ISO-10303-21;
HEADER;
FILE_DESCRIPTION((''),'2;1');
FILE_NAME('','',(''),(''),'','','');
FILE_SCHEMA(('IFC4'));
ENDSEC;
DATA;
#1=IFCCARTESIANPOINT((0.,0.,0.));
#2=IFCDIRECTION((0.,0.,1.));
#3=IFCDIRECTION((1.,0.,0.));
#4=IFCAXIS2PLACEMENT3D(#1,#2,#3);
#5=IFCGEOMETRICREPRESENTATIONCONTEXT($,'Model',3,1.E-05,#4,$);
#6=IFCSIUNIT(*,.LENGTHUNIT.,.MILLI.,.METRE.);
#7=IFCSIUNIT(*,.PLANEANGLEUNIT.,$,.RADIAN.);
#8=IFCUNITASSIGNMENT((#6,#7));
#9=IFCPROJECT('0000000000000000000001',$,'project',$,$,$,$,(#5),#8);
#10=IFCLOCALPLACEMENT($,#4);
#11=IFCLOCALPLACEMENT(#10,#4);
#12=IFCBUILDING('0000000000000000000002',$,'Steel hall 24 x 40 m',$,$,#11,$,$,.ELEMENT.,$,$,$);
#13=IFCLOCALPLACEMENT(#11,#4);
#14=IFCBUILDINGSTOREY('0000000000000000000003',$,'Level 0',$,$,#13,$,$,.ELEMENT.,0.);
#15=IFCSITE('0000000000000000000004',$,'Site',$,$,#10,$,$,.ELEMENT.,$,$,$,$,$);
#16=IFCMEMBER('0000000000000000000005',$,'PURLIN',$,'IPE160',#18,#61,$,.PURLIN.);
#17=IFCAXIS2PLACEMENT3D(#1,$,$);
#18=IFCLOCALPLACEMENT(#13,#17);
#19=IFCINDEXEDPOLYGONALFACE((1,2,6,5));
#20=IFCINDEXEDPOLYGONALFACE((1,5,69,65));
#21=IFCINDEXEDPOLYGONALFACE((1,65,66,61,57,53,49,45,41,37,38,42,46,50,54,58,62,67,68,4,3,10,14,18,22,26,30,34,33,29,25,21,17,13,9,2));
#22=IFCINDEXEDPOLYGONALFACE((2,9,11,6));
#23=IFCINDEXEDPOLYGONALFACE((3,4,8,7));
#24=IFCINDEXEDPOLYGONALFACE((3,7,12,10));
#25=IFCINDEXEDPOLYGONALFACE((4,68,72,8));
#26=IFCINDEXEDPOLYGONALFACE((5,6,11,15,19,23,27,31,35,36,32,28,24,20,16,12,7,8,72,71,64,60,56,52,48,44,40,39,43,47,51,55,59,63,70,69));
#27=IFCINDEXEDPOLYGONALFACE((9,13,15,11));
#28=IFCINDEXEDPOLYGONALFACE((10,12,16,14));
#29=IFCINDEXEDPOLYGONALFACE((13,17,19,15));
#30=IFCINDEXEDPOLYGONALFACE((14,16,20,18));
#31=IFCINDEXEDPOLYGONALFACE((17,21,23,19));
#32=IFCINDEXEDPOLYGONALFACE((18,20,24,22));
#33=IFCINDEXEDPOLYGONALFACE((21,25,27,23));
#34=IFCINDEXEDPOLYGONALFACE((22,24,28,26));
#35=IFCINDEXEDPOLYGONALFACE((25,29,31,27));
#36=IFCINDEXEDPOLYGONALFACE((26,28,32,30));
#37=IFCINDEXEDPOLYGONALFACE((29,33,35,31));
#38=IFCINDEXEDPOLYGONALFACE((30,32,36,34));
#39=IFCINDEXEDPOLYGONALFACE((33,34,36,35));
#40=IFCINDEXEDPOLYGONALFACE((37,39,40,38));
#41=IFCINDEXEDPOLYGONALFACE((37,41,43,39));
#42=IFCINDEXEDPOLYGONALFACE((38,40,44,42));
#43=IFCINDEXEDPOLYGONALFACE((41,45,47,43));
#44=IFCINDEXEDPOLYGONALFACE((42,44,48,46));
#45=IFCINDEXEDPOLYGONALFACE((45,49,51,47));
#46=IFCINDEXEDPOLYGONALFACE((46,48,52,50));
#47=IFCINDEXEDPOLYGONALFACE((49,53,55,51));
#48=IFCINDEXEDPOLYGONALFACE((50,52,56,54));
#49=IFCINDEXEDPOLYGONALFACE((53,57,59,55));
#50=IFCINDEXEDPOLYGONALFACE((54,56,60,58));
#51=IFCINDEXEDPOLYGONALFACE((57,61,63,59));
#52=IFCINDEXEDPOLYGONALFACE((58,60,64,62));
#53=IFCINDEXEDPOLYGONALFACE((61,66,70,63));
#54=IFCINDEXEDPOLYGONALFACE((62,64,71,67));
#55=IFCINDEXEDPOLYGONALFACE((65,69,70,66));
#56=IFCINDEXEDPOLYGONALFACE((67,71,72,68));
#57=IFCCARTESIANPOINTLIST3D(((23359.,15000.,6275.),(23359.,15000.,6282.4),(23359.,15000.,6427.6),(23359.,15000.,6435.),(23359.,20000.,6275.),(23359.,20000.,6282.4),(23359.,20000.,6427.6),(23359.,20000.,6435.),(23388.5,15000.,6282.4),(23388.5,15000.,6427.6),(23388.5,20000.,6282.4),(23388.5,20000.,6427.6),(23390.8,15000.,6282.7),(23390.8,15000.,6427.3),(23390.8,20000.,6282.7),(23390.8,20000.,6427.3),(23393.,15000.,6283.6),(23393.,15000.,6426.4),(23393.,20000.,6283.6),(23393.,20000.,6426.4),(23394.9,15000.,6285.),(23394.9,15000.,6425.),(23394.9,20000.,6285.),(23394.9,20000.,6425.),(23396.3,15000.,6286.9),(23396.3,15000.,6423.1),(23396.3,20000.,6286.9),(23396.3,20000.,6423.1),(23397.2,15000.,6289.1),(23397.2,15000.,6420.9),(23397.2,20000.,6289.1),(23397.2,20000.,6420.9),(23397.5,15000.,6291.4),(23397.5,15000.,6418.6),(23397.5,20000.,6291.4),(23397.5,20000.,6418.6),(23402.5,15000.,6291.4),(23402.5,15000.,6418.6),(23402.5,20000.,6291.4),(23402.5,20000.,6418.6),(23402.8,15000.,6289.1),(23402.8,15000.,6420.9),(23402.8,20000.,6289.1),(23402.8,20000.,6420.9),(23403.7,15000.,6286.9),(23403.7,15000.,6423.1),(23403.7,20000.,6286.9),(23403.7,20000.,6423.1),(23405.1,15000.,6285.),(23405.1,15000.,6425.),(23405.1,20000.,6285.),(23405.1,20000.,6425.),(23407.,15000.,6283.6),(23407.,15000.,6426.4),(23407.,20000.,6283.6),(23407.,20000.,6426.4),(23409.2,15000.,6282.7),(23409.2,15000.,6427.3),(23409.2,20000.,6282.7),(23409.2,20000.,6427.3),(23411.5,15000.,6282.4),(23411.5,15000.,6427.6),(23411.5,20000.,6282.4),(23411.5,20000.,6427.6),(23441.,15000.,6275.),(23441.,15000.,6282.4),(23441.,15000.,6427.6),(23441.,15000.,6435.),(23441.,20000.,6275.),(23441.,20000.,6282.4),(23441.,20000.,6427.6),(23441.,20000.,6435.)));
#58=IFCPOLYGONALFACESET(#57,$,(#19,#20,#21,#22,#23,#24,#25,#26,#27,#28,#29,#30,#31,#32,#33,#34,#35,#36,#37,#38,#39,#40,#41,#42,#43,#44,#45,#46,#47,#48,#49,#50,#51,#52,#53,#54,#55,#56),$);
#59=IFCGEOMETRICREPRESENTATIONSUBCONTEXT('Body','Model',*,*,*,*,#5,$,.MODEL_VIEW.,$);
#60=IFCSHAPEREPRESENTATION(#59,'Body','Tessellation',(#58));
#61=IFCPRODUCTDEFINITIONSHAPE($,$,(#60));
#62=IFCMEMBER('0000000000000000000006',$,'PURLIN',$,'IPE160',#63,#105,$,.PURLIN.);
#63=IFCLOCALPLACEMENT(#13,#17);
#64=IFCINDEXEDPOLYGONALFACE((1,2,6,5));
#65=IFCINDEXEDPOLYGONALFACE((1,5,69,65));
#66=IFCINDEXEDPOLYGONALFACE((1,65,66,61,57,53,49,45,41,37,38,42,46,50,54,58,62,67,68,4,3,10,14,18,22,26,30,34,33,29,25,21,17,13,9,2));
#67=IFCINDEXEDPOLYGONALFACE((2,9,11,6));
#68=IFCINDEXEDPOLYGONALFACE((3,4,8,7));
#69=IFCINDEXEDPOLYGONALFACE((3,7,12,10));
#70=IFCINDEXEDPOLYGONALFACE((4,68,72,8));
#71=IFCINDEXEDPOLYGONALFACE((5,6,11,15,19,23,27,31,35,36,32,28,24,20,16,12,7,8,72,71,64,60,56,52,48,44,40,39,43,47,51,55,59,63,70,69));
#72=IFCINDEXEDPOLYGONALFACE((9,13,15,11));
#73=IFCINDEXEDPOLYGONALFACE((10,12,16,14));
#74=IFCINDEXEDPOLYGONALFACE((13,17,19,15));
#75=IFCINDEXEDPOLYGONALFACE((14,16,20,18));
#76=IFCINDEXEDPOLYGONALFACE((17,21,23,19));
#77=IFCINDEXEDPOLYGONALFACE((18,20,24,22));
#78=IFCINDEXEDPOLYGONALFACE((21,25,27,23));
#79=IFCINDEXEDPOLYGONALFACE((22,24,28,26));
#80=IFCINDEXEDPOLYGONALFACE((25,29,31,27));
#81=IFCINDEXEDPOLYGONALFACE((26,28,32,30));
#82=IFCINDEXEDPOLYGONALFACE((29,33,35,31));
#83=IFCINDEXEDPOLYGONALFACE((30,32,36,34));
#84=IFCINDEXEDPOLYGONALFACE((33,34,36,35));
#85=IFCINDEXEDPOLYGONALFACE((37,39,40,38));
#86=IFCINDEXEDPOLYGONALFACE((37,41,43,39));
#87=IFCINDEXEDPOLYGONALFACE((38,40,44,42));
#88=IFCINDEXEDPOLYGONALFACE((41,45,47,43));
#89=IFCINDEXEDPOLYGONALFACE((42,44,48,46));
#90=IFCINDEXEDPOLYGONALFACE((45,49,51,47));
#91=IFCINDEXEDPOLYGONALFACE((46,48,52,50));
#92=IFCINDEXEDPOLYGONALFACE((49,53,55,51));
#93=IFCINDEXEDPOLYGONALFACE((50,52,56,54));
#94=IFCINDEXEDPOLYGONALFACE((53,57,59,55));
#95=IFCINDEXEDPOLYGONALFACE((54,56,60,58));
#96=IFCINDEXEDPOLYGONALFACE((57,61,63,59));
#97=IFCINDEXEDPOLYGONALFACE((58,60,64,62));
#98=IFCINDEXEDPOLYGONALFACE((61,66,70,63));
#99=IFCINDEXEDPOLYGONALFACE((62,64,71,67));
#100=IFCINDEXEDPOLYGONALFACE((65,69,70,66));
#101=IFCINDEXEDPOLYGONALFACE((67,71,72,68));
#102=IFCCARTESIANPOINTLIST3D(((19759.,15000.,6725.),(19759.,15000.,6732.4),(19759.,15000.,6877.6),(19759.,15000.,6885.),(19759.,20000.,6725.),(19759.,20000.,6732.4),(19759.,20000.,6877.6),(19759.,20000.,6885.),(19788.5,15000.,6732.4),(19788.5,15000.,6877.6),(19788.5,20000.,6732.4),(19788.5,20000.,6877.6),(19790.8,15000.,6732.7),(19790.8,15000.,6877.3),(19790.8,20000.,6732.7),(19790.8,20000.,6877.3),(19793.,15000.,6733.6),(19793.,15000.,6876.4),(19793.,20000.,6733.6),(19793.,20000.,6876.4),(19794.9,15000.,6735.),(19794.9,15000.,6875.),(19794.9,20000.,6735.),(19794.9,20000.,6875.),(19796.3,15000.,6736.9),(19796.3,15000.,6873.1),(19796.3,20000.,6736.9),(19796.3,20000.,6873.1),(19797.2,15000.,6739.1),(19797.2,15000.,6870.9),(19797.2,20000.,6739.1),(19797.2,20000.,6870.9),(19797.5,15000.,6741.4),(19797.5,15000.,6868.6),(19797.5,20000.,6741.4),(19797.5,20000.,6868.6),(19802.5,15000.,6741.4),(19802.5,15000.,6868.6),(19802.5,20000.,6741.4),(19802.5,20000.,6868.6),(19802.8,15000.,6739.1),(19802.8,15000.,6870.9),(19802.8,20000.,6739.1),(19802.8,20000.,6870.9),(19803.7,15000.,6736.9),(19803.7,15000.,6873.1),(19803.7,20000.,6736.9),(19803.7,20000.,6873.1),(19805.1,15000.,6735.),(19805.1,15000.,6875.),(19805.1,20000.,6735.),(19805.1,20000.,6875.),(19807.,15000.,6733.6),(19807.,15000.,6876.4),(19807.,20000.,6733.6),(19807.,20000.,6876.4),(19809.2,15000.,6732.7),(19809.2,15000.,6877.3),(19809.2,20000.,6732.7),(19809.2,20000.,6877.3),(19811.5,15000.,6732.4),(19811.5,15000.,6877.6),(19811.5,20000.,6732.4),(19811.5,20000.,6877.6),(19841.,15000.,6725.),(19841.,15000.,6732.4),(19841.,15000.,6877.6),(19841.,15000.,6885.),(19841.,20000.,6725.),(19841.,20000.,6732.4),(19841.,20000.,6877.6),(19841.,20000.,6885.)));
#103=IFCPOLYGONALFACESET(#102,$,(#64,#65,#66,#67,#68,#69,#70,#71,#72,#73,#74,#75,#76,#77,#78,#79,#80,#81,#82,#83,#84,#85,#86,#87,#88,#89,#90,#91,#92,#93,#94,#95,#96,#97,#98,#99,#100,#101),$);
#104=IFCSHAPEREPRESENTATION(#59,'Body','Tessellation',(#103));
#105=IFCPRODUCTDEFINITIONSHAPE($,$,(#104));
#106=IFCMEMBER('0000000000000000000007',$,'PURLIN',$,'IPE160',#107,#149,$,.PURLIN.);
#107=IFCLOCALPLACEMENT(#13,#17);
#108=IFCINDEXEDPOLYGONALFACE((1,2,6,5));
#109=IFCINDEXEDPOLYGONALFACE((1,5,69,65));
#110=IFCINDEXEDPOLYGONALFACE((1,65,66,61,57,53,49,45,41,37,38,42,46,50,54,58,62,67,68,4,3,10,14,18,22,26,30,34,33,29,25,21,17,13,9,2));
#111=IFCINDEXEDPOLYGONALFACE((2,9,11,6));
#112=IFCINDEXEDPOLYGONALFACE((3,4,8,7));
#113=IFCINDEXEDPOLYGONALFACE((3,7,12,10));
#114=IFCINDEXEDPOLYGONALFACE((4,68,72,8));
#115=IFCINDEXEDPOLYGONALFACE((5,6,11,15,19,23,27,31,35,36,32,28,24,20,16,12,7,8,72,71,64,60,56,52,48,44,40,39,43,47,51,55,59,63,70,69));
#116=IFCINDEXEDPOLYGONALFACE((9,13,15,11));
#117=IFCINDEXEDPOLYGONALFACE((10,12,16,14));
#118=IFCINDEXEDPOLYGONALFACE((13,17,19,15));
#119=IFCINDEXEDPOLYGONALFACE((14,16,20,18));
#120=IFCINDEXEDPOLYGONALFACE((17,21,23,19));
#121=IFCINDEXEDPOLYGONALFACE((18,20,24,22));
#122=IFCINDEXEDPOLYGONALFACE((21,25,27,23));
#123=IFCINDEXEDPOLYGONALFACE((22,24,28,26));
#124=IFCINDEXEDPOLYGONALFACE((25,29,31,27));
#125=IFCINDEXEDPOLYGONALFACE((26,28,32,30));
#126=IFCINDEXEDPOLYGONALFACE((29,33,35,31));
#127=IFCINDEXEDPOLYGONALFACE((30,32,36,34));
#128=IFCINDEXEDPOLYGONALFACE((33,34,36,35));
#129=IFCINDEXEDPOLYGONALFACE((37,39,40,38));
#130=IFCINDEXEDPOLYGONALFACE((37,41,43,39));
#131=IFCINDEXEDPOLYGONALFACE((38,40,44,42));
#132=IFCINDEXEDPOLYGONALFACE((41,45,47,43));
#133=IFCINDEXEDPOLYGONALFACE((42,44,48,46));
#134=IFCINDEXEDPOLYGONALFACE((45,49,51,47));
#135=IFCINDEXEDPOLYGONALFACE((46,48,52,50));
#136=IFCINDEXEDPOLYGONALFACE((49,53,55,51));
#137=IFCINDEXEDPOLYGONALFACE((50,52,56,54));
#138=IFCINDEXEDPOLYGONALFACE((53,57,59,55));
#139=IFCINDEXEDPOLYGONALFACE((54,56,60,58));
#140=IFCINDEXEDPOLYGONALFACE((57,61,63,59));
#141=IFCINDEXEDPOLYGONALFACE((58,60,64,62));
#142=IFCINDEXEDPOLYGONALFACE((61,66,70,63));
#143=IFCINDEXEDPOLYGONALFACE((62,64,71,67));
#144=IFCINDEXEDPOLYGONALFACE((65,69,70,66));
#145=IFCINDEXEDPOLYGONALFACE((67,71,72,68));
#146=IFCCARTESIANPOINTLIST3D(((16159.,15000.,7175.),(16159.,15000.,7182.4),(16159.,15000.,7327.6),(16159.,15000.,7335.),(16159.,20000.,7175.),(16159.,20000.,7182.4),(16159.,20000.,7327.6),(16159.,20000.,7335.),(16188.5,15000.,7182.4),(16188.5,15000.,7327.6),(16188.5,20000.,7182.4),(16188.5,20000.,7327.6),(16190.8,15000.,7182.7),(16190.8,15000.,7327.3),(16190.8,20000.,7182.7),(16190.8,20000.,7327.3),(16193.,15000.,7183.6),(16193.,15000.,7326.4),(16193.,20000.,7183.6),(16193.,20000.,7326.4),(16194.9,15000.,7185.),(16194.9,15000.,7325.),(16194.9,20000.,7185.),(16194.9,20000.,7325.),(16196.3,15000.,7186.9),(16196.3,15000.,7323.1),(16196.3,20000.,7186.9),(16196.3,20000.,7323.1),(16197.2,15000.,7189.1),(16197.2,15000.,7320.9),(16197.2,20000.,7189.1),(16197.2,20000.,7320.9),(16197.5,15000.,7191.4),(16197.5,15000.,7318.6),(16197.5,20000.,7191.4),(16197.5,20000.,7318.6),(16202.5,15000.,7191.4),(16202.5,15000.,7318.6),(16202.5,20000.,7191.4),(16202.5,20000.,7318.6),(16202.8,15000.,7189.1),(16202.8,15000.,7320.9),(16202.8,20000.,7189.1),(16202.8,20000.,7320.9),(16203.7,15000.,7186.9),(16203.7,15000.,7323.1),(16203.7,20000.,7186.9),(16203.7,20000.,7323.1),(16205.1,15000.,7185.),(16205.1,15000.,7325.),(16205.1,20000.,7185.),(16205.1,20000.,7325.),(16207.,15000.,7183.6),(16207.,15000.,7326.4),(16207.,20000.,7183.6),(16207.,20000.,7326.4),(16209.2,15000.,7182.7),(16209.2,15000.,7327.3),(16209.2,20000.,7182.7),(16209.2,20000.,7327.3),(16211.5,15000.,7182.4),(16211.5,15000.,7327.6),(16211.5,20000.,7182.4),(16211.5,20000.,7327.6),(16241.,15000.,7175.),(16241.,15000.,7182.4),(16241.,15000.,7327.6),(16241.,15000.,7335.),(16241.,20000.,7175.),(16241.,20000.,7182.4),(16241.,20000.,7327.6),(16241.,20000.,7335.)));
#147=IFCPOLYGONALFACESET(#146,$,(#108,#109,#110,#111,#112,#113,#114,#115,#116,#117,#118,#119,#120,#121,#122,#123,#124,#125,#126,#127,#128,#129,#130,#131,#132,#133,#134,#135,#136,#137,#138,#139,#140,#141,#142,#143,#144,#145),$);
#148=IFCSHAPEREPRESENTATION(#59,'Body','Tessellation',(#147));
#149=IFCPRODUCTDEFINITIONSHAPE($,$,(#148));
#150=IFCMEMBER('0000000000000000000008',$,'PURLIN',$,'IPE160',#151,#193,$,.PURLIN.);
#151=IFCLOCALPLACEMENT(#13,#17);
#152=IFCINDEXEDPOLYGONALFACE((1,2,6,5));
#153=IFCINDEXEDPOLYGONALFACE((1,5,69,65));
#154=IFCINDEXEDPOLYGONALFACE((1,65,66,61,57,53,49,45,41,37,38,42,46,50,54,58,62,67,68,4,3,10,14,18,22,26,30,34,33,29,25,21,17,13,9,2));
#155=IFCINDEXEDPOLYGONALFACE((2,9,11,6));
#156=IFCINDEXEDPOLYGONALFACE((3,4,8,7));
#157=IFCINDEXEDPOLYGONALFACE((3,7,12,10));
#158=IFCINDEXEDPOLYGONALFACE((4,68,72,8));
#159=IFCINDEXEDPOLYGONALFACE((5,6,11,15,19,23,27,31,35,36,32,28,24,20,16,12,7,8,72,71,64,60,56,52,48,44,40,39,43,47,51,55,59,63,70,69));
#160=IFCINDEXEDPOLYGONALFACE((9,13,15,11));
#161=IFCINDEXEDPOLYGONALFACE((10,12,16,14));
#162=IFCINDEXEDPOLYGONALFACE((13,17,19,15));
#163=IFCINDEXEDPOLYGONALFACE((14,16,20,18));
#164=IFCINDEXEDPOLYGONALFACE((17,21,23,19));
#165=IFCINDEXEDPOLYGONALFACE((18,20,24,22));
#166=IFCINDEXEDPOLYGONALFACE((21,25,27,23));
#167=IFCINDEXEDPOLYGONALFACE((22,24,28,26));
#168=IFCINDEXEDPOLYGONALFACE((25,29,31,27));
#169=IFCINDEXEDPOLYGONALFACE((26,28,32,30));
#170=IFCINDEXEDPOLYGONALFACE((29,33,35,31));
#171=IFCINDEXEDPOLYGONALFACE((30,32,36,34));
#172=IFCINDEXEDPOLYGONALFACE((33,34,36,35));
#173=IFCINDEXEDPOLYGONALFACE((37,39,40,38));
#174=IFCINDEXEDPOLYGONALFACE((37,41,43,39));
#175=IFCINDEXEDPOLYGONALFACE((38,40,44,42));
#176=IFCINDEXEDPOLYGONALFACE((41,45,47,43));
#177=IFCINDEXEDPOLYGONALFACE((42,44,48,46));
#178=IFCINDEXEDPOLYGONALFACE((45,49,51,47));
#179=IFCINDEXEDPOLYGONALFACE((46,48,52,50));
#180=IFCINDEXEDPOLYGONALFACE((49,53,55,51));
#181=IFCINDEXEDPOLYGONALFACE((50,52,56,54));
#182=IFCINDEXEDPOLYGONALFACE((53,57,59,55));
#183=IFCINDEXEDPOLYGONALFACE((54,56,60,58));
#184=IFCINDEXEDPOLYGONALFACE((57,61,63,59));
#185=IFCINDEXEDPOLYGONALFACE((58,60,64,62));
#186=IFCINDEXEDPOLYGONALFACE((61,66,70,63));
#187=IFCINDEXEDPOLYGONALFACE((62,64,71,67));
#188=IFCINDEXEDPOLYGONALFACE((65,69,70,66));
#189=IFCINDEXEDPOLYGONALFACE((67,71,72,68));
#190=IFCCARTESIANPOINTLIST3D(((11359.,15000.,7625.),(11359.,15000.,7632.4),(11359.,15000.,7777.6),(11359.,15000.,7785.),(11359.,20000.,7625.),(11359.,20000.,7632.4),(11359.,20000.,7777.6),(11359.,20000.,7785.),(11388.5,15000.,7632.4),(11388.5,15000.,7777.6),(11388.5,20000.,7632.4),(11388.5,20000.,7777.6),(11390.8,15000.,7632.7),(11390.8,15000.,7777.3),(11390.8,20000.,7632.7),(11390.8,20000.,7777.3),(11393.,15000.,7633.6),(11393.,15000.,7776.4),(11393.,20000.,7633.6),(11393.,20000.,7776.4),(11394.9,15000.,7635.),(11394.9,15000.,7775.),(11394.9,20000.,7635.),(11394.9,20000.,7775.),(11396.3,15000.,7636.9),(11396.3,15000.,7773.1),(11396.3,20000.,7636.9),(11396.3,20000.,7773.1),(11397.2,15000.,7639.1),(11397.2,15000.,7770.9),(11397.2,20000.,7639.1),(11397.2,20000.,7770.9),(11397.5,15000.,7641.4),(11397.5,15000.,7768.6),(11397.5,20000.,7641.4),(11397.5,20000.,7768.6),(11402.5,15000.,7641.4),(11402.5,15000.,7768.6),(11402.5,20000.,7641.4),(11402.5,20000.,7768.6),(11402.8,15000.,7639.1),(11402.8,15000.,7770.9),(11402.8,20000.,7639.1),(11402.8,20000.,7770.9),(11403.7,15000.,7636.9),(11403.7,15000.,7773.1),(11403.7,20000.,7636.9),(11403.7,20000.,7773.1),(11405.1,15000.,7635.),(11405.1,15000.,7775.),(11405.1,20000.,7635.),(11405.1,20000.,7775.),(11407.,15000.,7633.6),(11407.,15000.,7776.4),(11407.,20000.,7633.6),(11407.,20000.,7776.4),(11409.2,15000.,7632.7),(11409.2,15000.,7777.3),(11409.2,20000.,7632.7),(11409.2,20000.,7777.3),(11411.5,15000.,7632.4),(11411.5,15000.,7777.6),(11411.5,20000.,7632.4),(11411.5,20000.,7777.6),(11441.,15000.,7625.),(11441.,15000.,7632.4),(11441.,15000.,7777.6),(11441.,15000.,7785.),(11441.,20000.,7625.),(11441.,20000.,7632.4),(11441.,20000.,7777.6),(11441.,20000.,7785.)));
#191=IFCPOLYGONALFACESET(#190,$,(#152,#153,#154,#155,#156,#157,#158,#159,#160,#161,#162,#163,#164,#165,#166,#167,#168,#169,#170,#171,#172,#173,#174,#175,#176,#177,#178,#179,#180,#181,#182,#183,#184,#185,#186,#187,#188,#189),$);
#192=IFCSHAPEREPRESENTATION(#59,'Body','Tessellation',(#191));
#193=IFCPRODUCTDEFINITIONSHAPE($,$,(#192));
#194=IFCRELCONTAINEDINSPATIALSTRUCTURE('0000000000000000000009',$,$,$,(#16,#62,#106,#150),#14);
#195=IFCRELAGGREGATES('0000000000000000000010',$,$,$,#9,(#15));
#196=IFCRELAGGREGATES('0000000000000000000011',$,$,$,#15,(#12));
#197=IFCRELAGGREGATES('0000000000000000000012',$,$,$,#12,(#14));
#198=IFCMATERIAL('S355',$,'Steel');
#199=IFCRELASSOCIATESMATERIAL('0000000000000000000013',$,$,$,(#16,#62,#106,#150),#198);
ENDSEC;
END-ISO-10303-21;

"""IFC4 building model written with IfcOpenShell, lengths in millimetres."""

from ifc_helpers import new_model, si_unit, frame, origin_with_axes, place, context, subcontext, project, spatial, i_section, extrude, material, element, save


model = new_model("IFC4")

# Units and contexts
model_context = context("Model", 3, precision=1e-05, world=origin_with_axes())
body_context = subcontext(model_context, "Body", "Model", "MODEL_VIEW")
ifc_project = project(units=[si_unit("LENGTHUNIT", "METRE", prefix="MILLI"), si_unit("PLANEANGLEUNIT", "RADIAN")], contexts=[model_context])

# Site, building, storey
site_placement = place(None, origin_with_axes())
site = spatial("IfcSite", under=ifc_project, at=site_placement, Name="Site", CompositionType="ELEMENT")
building_placement = place(site_placement, origin_with_axes())
building = spatial("IfcBuilding", under=site, at=building_placement, Name="Steel hall 24 x 40 m", CompositionType="ELEMENT")
storey_placement = place(building_placement, origin_with_axes())
storey = spatial("IfcBuildingStorey", under=building, at=storey_placement, Name="Level 0", CompositionType="ELEMENT", Elevation=0.0)

# Shared definitions
ifc_material = material(Name="S355", Category="Steel")

# Members
for number, where, z_axis, x_axis, name in (
    (1, (23400.0, 15000.0, 6355.0), (0.0, 1.0, 0.0), (1.0, 0.0, 0.0), "PURLIN"),
    (2, (19800.0, 15000.0, 6805.0), (0.0, 1.0, 0.0), (1.0, 0.0, 0.0), "PURLIN"),
    (3, (16200.0, 15000.0, 7255.0), (0.0, 1.0, 0.0), (1.0, 0.0, 0.0), "PURLIN"),
    (4, (11400.0, 15000.0, 7705.0), (0.0, 1.0, 0.0), (1.0, 0.0, 0.0), "PURLIN"),
):
    element("IfcMember", number, at=place(storey_placement, frame(where, z_axis=z_axis, x_axis=x_axis)), inside=storey, material=ifc_material, Name=name, ObjectType="IPE160", PredefinedType="PURLIN", context=body_context, shape_type="SweptSolid", body=[
        extrude(i_section(OverallWidth=82.0, OverallDepth=160.0, WebThickness=5.0, FlangeThickness=7.4, FilletRadius=9.0), origin_with_axes(), (0.0, 0.0, 1.0), 5000.0),
    ])

save(model, "model.ifc")
